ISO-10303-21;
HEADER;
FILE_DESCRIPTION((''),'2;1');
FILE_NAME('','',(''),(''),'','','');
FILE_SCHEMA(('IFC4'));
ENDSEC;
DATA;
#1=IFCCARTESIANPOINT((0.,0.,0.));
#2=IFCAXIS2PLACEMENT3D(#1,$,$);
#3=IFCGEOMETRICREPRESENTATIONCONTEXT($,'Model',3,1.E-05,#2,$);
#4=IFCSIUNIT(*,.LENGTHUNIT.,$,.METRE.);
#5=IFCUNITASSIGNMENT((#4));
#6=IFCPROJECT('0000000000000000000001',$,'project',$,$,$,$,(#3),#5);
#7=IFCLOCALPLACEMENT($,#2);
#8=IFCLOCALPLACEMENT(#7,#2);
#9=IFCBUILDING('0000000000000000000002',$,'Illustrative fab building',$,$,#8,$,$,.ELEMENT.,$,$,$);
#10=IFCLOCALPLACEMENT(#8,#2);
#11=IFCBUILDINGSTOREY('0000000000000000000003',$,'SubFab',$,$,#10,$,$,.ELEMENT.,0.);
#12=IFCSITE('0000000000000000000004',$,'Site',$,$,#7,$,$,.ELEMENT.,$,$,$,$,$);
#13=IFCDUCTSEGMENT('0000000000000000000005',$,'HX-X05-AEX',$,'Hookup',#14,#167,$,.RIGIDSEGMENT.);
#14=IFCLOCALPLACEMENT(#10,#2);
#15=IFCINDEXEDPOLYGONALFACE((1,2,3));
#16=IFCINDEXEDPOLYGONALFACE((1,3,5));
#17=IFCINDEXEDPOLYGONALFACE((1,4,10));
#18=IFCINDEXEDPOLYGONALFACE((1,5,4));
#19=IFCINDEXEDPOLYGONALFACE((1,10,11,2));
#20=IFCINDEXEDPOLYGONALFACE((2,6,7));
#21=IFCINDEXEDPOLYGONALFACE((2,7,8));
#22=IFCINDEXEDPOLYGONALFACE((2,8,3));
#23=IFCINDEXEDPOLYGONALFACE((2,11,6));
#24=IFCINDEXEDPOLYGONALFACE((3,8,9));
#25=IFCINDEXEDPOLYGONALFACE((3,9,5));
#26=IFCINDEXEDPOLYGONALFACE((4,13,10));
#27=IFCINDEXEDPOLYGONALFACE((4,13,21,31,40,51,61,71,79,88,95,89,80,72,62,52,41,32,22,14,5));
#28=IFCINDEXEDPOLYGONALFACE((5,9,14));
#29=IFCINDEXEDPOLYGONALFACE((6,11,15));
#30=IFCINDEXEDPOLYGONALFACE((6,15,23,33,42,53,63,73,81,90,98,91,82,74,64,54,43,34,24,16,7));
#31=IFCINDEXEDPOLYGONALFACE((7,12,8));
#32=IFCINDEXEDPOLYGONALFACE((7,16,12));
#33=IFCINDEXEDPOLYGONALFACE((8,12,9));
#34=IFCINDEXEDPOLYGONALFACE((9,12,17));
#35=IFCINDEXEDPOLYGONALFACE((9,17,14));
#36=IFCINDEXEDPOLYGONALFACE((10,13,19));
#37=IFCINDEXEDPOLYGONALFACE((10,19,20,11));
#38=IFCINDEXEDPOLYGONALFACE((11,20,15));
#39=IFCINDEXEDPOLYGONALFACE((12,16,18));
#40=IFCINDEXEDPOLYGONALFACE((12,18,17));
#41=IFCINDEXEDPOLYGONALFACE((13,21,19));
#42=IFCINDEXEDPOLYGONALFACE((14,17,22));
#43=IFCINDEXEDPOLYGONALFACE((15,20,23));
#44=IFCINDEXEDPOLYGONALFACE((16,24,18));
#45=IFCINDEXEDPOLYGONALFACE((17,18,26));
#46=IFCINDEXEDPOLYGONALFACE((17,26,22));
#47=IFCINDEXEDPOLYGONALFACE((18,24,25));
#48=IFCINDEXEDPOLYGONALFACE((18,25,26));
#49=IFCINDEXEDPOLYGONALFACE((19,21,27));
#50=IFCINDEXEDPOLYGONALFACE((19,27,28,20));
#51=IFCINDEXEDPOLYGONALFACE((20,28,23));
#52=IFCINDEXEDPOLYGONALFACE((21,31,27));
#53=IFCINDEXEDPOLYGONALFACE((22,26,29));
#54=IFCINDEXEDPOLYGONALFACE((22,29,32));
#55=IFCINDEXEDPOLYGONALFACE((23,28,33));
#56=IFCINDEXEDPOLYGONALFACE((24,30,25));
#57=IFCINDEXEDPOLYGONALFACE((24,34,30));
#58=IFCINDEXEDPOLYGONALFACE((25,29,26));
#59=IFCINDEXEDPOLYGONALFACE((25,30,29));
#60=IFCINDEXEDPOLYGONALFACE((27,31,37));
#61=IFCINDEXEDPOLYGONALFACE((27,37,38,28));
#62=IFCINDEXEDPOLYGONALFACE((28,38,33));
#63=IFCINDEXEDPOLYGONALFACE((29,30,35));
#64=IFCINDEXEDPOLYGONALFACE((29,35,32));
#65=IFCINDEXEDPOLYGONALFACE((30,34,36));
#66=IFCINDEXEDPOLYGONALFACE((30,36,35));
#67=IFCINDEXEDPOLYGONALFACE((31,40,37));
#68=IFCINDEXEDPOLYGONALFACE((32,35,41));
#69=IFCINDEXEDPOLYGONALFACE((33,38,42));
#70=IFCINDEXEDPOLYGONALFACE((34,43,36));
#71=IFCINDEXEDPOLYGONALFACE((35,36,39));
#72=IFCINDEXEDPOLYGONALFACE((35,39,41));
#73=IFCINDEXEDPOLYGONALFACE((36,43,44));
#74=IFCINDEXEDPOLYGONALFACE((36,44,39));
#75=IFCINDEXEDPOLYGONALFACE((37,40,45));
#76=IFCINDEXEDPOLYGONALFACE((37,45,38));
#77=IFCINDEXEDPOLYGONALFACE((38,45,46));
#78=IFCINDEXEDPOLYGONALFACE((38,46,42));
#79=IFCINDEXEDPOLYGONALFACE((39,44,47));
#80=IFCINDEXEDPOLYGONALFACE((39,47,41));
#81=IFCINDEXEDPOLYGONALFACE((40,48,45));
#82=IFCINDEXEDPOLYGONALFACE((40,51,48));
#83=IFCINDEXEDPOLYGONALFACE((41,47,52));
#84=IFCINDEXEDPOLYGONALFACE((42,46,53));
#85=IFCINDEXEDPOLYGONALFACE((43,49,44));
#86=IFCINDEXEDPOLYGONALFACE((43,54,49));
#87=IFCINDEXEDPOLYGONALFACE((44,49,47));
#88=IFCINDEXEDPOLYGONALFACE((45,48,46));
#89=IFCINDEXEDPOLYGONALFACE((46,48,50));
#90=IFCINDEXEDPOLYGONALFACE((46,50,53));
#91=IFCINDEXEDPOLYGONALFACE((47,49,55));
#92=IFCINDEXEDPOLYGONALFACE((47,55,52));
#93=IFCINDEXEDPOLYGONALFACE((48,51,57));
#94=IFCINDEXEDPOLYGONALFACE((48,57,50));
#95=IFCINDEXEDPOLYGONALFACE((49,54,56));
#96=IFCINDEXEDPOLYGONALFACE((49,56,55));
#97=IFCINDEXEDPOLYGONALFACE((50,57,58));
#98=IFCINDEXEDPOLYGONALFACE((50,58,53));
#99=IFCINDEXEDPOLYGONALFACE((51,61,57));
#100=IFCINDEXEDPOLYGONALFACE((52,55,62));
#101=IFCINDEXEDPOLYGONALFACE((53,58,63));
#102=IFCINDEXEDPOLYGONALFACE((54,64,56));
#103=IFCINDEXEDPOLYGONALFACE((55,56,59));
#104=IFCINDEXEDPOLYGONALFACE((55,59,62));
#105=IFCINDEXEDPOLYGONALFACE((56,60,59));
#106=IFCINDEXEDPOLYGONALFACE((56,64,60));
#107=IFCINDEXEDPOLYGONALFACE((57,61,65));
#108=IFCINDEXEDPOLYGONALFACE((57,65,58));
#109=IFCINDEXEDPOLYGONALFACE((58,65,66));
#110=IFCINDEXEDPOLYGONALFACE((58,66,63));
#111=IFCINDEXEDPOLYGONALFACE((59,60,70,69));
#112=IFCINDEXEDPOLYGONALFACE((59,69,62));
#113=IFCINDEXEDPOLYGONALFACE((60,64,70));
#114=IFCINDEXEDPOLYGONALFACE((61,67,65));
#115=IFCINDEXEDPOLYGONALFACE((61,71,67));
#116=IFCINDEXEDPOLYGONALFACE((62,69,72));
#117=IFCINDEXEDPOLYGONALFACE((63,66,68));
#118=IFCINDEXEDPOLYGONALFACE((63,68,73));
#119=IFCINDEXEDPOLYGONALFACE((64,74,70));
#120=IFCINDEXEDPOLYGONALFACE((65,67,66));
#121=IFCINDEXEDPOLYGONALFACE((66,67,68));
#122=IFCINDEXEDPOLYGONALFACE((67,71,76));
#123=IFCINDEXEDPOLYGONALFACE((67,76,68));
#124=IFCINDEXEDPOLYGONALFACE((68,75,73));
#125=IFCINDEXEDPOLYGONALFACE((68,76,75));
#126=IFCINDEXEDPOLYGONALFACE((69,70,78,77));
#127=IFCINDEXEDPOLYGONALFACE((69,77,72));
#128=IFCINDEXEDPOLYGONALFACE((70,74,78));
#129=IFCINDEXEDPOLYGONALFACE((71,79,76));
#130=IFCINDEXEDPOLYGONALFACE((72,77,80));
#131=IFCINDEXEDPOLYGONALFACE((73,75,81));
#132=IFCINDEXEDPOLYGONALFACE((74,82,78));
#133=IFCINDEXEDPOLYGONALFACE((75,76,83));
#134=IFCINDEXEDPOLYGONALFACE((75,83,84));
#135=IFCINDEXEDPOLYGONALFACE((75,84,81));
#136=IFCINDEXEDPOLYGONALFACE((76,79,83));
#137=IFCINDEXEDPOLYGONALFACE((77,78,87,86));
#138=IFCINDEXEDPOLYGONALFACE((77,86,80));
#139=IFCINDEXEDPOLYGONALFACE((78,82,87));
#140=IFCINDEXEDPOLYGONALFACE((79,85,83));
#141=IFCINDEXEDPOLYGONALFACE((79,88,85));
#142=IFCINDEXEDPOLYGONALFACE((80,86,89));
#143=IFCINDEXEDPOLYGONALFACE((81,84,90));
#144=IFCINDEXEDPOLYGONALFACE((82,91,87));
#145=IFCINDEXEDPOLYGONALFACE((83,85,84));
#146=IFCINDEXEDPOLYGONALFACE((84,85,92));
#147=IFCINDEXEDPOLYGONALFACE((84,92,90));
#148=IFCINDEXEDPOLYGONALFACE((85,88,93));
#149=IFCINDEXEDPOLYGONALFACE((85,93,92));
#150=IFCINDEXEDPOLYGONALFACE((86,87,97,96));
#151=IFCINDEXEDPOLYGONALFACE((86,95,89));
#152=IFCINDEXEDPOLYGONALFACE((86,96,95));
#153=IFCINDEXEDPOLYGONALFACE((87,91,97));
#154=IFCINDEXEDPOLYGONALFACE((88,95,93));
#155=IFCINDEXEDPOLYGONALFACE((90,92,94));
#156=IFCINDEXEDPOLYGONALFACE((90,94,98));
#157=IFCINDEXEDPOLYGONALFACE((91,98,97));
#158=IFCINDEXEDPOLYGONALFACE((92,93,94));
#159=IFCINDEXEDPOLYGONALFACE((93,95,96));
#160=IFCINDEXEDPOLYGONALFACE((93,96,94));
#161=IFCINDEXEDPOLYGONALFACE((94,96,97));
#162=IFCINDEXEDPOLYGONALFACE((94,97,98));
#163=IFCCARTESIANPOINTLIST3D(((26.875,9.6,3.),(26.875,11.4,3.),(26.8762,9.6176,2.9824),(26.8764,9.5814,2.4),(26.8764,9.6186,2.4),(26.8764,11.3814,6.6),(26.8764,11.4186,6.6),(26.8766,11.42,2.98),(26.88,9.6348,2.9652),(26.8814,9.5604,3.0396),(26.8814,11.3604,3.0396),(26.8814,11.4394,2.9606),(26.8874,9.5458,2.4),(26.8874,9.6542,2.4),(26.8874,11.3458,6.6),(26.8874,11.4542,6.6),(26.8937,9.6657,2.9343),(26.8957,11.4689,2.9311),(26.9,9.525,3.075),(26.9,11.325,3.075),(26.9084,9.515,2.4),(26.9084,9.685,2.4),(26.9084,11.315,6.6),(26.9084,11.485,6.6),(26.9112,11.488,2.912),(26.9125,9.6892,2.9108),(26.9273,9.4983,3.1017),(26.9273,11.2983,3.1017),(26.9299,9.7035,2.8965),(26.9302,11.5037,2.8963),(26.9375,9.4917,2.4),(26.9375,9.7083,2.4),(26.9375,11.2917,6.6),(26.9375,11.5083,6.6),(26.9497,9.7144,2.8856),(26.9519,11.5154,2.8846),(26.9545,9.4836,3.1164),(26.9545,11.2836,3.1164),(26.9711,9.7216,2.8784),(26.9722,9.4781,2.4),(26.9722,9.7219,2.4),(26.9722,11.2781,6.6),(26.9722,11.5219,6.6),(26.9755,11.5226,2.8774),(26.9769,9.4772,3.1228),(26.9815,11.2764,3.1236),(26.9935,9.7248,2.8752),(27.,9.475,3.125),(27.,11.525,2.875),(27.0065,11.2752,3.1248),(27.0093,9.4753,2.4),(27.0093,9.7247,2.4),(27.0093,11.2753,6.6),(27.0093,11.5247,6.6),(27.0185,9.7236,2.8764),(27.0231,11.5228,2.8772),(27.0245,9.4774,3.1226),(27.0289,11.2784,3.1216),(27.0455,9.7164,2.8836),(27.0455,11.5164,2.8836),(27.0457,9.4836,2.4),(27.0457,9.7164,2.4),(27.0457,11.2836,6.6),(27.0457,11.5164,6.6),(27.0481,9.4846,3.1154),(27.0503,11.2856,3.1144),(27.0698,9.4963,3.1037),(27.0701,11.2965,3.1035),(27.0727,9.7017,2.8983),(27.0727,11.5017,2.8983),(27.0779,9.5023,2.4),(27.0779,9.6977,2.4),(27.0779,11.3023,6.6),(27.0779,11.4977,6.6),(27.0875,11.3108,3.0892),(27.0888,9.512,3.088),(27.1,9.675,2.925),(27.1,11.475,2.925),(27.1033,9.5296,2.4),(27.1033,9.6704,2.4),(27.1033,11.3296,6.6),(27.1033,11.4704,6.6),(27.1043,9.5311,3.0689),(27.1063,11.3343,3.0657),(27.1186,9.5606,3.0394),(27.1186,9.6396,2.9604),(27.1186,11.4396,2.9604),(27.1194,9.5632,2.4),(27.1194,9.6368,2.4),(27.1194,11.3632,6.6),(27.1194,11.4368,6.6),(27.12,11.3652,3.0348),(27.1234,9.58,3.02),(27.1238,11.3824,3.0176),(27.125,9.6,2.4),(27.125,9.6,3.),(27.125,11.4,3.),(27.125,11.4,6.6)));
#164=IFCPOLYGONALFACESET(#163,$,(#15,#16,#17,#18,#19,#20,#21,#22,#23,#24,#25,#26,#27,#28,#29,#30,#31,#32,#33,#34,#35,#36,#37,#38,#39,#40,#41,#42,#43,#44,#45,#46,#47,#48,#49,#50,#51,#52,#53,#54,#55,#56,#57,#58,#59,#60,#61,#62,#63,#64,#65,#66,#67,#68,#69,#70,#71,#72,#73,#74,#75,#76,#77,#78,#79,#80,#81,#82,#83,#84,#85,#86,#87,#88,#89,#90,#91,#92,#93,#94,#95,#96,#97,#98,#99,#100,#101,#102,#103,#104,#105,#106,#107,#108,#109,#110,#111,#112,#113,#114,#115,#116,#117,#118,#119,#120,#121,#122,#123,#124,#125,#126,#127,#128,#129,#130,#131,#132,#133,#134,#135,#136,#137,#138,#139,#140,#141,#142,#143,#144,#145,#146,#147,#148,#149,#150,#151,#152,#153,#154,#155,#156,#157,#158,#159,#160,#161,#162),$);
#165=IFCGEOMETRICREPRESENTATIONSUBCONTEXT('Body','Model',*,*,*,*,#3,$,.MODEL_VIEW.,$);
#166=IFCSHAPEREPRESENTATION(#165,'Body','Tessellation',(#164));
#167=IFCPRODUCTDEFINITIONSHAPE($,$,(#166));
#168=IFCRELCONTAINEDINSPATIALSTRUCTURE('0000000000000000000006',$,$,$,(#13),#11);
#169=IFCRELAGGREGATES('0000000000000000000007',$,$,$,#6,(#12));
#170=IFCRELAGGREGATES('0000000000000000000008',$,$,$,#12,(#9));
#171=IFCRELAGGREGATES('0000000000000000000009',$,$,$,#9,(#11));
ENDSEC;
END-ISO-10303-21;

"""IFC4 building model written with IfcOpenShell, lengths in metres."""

from ifc_helpers import new_model, entity, si_unit, origin, place, context, subcontext, project, spatial, element, save


model = new_model("IFC4")

# Units and contexts
model_context = context("Model", 3, precision=1e-05, world=origin())
body_context = subcontext(model_context, "Body", "Model", "MODEL_VIEW")
ifc_project = project(units=[si_unit("LENGTHUNIT", "METRE")], contexts=[model_context])

# Site, building, storey
site_placement = place(None, origin())
site = spatial("IfcSite", under=ifc_project, at=site_placement, Name="Site", CompositionType="ELEMENT")
building_placement = place(site_placement, origin())
building = spatial("IfcBuilding", under=site, at=building_placement, Name="Illustrative fab building", CompositionType="ELEMENT")
storey_placement = place(building_placement, origin())
storey = spatial("IfcBuildingStorey", under=building, at=storey_placement, Name="SubFab", CompositionType="ELEMENT", Elevation=0.0)

# Duct segment
duct_segment_1_placement = place(storey_placement, origin())
element("IfcDuctSegment", 1, at=duct_segment_1_placement, inside=storey, Name="HX-X05-AEX", ObjectType="Hookup", PredefinedType="RIGIDSEGMENT", context=body_context, shape_type="AdvancedSweptSolid", body=[
    entity("IfcSweptDiskSolid", entity("IfcPolyline", [entity("IfcCartesianPoint", [27.0, 9.6, 2.4]), entity("IfcCartesianPoint", [27.0, 9.6, 3.0]), entity("IfcCartesianPoint", [27.0, 11.4, 3.0]), entity("IfcCartesianPoint", [27.0, 11.4, 6.6])]), 0.125),
])

save(model, "model.ifc")
